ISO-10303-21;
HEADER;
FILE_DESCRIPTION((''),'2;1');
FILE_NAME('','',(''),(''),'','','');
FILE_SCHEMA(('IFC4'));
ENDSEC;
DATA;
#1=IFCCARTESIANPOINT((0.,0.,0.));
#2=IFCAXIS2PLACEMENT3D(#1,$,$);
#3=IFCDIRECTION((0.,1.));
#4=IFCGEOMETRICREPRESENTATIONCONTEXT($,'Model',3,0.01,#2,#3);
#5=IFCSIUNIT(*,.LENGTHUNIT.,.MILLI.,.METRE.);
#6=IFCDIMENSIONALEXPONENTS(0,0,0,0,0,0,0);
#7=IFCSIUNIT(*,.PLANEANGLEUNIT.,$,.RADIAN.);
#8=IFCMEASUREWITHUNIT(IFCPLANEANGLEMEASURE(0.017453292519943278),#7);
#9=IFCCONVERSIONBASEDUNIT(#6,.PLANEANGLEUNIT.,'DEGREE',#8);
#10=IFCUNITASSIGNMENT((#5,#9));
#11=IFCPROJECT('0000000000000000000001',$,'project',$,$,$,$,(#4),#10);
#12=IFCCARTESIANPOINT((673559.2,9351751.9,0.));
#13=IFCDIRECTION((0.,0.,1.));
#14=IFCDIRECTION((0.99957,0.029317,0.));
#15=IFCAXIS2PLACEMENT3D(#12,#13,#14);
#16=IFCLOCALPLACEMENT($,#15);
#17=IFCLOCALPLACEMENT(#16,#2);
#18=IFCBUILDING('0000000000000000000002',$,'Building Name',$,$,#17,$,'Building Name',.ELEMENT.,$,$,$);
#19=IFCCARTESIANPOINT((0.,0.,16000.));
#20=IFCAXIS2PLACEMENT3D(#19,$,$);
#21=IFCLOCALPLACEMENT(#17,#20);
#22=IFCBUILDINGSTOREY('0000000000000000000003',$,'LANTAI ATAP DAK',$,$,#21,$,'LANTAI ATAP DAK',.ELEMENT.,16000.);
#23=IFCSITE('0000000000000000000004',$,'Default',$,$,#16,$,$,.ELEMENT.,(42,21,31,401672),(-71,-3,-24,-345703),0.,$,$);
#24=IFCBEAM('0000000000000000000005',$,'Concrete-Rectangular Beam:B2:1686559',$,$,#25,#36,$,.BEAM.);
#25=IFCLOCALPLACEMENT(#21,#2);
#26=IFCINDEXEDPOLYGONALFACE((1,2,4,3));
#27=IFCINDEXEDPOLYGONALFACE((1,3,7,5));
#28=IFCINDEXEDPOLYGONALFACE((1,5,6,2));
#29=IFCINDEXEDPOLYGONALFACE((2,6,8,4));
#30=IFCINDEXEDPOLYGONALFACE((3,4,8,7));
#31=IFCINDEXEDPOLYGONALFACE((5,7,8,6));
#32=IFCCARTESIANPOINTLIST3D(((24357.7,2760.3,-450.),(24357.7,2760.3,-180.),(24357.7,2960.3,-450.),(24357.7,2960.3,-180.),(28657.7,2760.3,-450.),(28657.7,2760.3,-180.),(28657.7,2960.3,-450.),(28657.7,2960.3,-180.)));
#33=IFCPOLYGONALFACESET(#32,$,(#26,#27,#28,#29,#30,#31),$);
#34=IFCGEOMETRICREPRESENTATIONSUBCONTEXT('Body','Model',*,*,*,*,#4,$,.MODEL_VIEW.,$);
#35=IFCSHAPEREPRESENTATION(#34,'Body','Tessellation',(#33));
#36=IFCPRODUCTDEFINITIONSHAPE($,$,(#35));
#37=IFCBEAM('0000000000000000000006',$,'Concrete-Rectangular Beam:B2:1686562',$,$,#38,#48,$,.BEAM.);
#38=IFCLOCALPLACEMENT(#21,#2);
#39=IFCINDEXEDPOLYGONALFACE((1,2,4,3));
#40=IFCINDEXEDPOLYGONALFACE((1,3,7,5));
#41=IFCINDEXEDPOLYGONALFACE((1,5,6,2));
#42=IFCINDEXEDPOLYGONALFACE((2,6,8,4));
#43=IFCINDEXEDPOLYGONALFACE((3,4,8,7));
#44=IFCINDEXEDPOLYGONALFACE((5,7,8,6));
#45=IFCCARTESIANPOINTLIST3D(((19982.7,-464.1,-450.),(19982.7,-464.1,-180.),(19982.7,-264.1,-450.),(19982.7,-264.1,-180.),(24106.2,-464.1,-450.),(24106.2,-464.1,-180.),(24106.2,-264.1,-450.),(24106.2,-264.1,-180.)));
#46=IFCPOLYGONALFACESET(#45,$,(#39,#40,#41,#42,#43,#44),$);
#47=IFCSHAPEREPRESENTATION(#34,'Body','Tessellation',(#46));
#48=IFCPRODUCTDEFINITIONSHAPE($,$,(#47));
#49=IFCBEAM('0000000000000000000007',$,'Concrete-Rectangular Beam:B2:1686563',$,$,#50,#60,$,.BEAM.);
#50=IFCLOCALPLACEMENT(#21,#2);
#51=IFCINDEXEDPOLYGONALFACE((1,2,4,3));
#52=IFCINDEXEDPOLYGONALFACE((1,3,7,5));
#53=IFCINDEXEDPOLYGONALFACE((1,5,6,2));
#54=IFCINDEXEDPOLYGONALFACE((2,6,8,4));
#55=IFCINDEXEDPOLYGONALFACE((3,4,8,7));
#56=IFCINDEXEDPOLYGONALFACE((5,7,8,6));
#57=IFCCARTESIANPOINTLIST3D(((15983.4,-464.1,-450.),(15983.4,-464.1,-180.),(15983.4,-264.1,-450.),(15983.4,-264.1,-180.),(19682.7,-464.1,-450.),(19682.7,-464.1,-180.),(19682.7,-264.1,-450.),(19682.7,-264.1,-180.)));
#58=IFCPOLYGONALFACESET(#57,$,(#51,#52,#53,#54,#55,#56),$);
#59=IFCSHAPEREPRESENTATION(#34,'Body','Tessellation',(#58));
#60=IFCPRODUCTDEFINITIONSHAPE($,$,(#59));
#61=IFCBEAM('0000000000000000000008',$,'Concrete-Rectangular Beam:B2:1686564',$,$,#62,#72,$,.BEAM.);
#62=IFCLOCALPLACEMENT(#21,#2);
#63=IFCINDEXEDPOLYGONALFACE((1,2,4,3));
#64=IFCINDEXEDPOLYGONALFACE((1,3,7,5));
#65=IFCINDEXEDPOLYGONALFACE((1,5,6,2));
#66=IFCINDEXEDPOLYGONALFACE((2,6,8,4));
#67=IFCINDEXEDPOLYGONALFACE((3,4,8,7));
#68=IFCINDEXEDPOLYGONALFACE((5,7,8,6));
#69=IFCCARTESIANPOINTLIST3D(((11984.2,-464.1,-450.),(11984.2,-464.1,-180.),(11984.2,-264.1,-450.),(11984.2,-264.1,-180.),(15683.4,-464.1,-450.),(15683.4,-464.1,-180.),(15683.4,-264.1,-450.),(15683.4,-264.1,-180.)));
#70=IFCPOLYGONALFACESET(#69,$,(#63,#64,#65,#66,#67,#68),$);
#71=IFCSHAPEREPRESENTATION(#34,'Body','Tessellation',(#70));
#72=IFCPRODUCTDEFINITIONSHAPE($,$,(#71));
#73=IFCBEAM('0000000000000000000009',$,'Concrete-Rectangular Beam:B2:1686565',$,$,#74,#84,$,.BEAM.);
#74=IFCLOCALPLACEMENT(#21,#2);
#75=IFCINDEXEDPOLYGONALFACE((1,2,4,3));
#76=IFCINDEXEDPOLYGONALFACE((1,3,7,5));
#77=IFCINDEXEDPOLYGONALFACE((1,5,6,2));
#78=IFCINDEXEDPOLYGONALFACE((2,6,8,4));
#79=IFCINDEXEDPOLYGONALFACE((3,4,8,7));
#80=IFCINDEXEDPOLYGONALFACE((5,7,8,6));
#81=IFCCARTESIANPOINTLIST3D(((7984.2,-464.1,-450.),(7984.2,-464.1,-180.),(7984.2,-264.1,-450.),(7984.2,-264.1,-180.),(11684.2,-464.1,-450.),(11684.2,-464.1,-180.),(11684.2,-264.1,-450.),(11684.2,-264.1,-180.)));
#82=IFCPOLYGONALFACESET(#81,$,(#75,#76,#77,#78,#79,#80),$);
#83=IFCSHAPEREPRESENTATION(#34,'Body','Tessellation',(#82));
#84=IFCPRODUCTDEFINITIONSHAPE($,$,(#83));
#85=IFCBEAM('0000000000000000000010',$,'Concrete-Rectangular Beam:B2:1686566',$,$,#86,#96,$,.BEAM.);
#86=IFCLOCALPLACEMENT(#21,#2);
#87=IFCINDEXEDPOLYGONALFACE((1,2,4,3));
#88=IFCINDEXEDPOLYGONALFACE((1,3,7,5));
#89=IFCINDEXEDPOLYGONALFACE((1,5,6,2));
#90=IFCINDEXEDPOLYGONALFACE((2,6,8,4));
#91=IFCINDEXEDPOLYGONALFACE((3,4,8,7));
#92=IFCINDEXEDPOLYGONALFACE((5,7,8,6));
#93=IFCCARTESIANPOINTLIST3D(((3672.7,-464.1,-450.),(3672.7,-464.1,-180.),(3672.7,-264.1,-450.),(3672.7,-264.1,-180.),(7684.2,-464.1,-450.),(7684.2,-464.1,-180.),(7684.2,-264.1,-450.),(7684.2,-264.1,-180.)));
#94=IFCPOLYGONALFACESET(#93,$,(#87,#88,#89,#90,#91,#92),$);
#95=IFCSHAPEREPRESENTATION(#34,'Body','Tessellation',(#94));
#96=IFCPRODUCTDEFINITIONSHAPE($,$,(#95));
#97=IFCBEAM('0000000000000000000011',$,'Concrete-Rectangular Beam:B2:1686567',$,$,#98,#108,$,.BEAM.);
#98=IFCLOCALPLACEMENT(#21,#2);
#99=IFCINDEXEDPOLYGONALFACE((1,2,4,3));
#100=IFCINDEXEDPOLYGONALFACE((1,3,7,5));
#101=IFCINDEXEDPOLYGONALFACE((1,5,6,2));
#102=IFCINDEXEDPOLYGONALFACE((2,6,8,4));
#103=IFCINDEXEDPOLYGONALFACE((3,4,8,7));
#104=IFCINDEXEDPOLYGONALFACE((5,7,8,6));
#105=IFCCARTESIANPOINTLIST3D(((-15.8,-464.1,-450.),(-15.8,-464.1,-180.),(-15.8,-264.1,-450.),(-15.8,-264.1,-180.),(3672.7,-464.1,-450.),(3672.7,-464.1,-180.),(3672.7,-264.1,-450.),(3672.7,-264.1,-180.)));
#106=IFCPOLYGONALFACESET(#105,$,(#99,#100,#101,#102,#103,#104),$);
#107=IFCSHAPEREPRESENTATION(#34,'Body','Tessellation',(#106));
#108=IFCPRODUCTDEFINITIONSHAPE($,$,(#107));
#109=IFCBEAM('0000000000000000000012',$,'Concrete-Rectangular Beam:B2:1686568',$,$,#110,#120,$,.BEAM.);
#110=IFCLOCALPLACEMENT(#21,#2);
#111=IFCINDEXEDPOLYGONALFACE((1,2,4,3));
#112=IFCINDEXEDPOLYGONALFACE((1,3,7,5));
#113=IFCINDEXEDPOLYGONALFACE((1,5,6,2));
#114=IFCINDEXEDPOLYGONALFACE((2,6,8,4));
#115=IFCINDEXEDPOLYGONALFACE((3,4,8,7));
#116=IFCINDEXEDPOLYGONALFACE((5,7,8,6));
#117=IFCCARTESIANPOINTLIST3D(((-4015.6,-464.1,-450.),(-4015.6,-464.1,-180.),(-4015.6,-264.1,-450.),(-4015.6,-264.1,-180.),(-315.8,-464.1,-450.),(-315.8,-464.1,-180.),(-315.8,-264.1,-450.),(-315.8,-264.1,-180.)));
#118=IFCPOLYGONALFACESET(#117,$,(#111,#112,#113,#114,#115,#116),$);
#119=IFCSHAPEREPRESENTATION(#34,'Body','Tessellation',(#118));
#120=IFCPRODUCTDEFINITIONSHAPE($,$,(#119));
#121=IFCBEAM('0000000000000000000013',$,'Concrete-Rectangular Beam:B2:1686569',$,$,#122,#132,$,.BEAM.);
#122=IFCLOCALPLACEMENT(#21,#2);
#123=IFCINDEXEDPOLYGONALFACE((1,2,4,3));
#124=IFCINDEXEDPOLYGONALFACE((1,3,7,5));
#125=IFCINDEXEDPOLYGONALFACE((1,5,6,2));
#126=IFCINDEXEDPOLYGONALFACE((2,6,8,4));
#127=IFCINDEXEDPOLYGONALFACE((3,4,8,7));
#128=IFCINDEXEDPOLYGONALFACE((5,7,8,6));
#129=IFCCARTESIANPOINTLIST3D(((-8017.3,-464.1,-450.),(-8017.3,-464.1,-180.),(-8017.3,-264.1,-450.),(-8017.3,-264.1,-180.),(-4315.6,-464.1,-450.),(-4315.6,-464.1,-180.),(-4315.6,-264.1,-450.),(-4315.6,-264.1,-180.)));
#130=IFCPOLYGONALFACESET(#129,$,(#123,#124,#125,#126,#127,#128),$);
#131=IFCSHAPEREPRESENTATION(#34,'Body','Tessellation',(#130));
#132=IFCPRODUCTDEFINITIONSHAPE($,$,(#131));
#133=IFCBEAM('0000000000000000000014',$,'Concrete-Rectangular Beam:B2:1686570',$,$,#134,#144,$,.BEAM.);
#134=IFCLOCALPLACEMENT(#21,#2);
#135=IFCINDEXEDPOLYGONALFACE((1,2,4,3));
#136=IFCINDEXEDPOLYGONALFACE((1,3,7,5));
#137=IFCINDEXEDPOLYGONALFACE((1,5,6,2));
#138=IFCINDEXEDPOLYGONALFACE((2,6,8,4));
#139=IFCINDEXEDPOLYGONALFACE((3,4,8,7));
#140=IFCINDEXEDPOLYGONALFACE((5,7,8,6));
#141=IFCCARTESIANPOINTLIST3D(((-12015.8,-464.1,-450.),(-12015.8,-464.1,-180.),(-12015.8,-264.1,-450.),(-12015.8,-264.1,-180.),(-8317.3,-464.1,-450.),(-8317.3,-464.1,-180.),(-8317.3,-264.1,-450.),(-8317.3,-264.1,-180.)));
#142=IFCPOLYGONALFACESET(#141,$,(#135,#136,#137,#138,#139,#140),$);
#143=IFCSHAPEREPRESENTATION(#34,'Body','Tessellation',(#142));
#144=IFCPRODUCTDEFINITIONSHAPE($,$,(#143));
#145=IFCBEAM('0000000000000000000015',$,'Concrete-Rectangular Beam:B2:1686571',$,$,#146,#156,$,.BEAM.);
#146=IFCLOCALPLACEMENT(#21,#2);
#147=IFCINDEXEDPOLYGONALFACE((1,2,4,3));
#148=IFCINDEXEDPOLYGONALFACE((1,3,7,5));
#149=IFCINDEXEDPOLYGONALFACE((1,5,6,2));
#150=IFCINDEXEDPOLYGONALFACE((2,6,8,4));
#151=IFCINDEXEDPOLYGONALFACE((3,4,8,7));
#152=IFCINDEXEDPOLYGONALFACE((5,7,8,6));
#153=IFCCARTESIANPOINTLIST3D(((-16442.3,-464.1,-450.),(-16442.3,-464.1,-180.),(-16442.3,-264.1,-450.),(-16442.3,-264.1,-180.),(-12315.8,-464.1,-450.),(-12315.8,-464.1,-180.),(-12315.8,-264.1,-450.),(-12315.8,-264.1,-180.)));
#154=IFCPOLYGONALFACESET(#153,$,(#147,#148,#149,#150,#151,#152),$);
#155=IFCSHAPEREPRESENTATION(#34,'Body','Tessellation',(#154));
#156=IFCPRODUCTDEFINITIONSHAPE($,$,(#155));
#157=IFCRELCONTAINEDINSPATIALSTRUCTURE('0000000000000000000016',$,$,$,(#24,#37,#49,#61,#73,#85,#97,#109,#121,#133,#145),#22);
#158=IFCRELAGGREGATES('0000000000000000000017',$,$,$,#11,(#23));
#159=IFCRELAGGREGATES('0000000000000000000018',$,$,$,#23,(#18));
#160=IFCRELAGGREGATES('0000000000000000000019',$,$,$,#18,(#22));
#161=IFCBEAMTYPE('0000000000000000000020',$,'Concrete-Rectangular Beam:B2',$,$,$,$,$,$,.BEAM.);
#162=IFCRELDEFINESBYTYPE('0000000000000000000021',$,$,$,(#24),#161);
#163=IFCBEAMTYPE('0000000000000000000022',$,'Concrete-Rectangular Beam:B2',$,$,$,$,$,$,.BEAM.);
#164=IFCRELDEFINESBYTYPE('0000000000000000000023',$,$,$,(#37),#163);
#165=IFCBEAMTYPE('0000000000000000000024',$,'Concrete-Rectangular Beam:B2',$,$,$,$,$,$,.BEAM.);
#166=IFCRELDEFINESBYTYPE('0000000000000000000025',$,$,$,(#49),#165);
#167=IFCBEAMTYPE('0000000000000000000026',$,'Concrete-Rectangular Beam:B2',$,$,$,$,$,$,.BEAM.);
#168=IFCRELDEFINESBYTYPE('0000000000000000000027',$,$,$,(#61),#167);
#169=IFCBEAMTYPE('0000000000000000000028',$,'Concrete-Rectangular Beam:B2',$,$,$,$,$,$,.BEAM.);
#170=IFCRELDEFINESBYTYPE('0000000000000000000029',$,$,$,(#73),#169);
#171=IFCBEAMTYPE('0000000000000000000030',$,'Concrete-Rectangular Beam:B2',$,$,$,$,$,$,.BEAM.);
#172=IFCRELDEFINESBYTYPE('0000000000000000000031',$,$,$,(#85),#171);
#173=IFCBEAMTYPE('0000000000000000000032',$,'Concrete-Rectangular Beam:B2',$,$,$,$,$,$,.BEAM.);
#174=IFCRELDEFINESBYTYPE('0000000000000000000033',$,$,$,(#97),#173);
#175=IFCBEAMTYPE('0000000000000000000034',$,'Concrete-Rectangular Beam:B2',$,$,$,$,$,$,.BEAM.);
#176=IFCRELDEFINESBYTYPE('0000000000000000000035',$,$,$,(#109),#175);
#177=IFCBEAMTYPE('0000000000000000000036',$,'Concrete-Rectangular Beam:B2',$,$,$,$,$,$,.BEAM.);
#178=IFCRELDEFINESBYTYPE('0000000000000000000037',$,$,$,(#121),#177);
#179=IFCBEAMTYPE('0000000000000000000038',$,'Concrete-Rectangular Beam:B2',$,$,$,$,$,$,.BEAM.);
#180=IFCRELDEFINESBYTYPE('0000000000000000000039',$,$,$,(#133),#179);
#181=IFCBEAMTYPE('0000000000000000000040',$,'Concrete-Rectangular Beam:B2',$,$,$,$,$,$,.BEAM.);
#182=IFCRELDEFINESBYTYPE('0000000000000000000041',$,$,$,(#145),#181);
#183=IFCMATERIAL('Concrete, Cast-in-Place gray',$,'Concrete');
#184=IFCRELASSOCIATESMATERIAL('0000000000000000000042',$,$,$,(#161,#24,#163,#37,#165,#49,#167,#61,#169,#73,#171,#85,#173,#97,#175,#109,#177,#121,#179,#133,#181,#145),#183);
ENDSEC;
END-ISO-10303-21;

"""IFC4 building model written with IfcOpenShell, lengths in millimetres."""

from ifc_helpers import new_model, entity, si_unit, converted_unit, direction, frame, origin, place, context, subcontext, project, spatial, indexed_curve, outline, extrude, source, transform, mapped, material, type_object, type_shapes, element, save


model = new_model("IFC4")

# Units and contexts
model_context = context("Model", 3, precision=0.01, world=origin(), true_north=direction((0.0, 1.0)))
body_context = subcontext(model_context, "Body", "Model", "MODEL_VIEW")
ifc_project = project(units=[si_unit("LENGTHUNIT", "METRE", prefix="MILLI"), converted_unit("PLANEANGLEUNIT", "DEGREE", entity("IfcPlaneAngleMeasure", 0.017453292519943278), si_unit("PLANEANGLEUNIT", "RADIAN"), dimensions=[0, 0, 0, 0, 0, 0, 0])], contexts=[model_context])

# Site, building, storey
site_placement = place(None, frame((673559.2, 9351751.9, 0.0), z_axis=(0.0, 0.0, 1.0), x_axis=(0.99957, 0.029317, 0.0)))
site = spatial("IfcSite", under=ifc_project, at=site_placement, Name="Default", CompositionType="ELEMENT", RefLatitude=(42, 21, 31, 401672), RefLongitude=(-71, -3, -24, -345703), RefElevation=0.0)
building_placement = place(site_placement, origin())
building = spatial("IfcBuilding", under=site, at=building_placement, Name="Building Name", LongName="Building Name", CompositionType="ELEMENT")
storey_placement = place(building_placement, frame((0.0, 0.0, 16000.0)))
storey = spatial("IfcBuildingStorey", under=building, at=storey_placement, Name="LANTAI ATAP DAK", LongName="LANTAI ATAP DAK", CompositionType="ELEMENT", Elevation=16000.0)

# Beams
ifc_material = material(Name="Concrete, Cast-in-Place gray", Category="Concrete")
beam_type_1 = type_object("IfcBeamType", Name="Concrete-Rectangular Beam:B2", PredefinedType="BEAM", material=ifc_material)
shared_shape_1 = source(origin(), body_context, "Body", "SweptSolid", [
    extrude(outline(indexed_curve([(-135.0, -100.0), (135.0, -100.0), (135.0, 100.0), (-135.0, 100.0), (-135.0, -100.0)], self_intersect=False)), frame((24357.7, 2860.3, 15685.0), z_axis=(1.0, 0.0, 0.0), x_axis=(0.0, 0.0, -1.0)), (0.0, 0.0, 1.0), 4300.0),
])
type_shapes(beam_type_1, [shared_shape_1])
beam_1_placement = place(storey_placement, frame((0.0, 0.0, -16000.0)))
element("IfcBeam", 1, at=beam_1_placement, inside=storey, type_object=beam_type_1, material=ifc_material, Name="Concrete-Rectangular Beam:B2:1686559", PredefinedType="BEAM", context=body_context, shape_type="MappedRepresentation", body=[
    mapped(shared_shape_1, transform((0.0, 0.0, 0.0), scale=1.0)),
])
beam_type_2 = type_object("IfcBeamType", Name="Concrete-Rectangular Beam:B2", PredefinedType="BEAM", material=ifc_material)
shared_shape_2 = source(origin(), body_context, "Body", "SweptSolid", [
    extrude(outline(indexed_curve([(-135.0, -100.0), (135.0, -100.0), (135.0, 100.0), (-135.0, 100.0), (-135.0, -100.0)], self_intersect=False)), frame((24106.2, -364.1, 15685.0), z_axis=(-1.0, 0.0, 0.0), x_axis=(0.0, 0.0, -1.0)), (0.0, 0.0, 1.0), 4123.5),
])
type_shapes(beam_type_2, [shared_shape_2])
beam_2_placement = place(storey_placement, frame((0.0, 0.0, -16000.0)))
element("IfcBeam", 2, at=beam_2_placement, inside=storey, type_object=beam_type_2, material=ifc_material, Name="Concrete-Rectangular Beam:B2:1686562", PredefinedType="BEAM", context=body_context, shape_type="MappedRepresentation", body=[
    mapped(shared_shape_2, transform((0.0, 0.0, 0.0), scale=1.0)),
])
beam_type_3 = type_object("IfcBeamType", Name="Concrete-Rectangular Beam:B2", PredefinedType="BEAM", material=ifc_material)
shared_shape_3 = source(origin(), body_context, "Body", "SweptSolid", [
    extrude(outline(indexed_curve([(-135.0, -100.0), (135.0, -100.0), (135.0, 100.0), (-135.0, 100.0), (-135.0, -100.0)], self_intersect=False)), frame((19682.7, -364.1, 15685.0), z_axis=(-1.0, 0.0, 0.0), x_axis=(0.0, 0.0, -1.0)), (0.0, 0.0, 1.0), 3699.3),
])
type_shapes(beam_type_3, [shared_shape_3])
beam_3_placement = place(storey_placement, frame((0.0, 0.0, -16000.0)))
element("IfcBeam", 3, at=beam_3_placement, inside=storey, type_object=beam_type_3, material=ifc_material, Name="Concrete-Rectangular Beam:B2:1686563", PredefinedType="BEAM", context=body_context, shape_type="MappedRepresentation", body=[
    mapped(shared_shape_3, transform((0.0, 0.0, 0.0), scale=1.0)),
])
beam_type_4 = type_object("IfcBeamType", Name="Concrete-Rectangular Beam:B2", PredefinedType="BEAM", material=ifc_material)
shared_shape_4 = source(origin(), body_context, "Body", "SweptSolid", [
    extrude(outline(indexed_curve([(-135.0, -100.0), (135.0, -100.0), (135.0, 100.0), (-135.0, 100.0), (-135.0, -100.0)], self_intersect=False)), frame((11984.2, -364.1, 15685.0), z_axis=(1.0, 0.0, 0.0), x_axis=(0.0, 0.0, -1.0)), (0.0, 0.0, 1.0), 3699.3),
])
type_shapes(beam_type_4, [shared_shape_4])
beam_4_placement = place(storey_placement, frame((0.0, 0.0, -16000.0)))
element("IfcBeam", 4, at=beam_4_placement, inside=storey, type_object=beam_type_4, material=ifc_material, Name="Concrete-Rectangular Beam:B2:1686564", PredefinedType="BEAM", context=body_context, shape_type="MappedRepresentation", body=[
    mapped(shared_shape_4, transform((0.0, 0.0, 0.0), scale=1.0)),
])
beam_type_5 = type_object("IfcBeamType", Name="Concrete-Rectangular Beam:B2", PredefinedType="BEAM", material=ifc_material)
shared_shape_5 = source(origin(), body_context, "Body", "SweptSolid", [
    extrude(outline(indexed_curve([(-135.0, -100.0), (135.0, -100.0), (135.0, 100.0), (-135.0, 100.0), (-135.0, -100.0)], self_intersect=False)), frame((11684.2, -364.1, 15685.0), z_axis=(-1.0, 0.0, 0.0), x_axis=(0.0, 0.0, -1.0)), (0.0, 0.0, 1.0), 3700.0),
])
type_shapes(beam_type_5, [shared_shape_5])
beam_5_placement = place(storey_placement, frame((0.0, 0.0, -16000.0)))
element("IfcBeam", 5, at=beam_5_placement, inside=storey, type_object=beam_type_5, material=ifc_material, Name="Concrete-Rectangular Beam:B2:1686565", PredefinedType="BEAM", context=body_context, shape_type="MappedRepresentation", body=[
    mapped(shared_shape_5, transform((0.0, 0.0, 0.0), scale=1.0)),
])
beam_type_6 = type_object("IfcBeamType", Name="Concrete-Rectangular Beam:B2", PredefinedType="BEAM", material=ifc_material)
shared_shape_6 = source(origin(), body_context, "Body", "SweptSolid", [
    extrude(outline(indexed_curve([(-135.0, -100.0), (135.0, -100.0), (135.0, 100.0), (-135.0, 100.0), (-135.0, -100.0)], self_intersect=False)), frame((7684.2, -364.1, 15685.0), z_axis=(-1.0, 0.0, 0.0), x_axis=(0.0, 0.0, -1.0)), (0.0, 0.0, 1.0), 4011.4),
])
type_shapes(beam_type_6, [shared_shape_6])
beam_6_placement = place(storey_placement, frame((0.0, 0.0, -16000.0)))
element("IfcBeam", 6, at=beam_6_placement, inside=storey, type_object=beam_type_6, material=ifc_material, Name="Concrete-Rectangular Beam:B2:1686566", PredefinedType="BEAM", context=body_context, shape_type="MappedRepresentation", body=[
    mapped(shared_shape_6, transform((0.0, 0.0, 0.0), scale=1.0)),
])
beam_type_7 = type_object("IfcBeamType", Name="Concrete-Rectangular Beam:B2", PredefinedType="BEAM", material=ifc_material)
shared_shape_7 = source(origin(), body_context, "Body", "SweptSolid", [
    extrude(outline(indexed_curve([(-135.0, -100.0), (135.0, -100.0), (135.0, 100.0), (-135.0, 100.0), (-135.0, -100.0)], self_intersect=False)), frame((3672.7, -364.1, 15685.0), z_axis=(-1.0, 0.0, 0.0), x_axis=(0.0, 0.0, -1.0)), (0.0, 0.0, 1.0), 3688.6),
])
type_shapes(beam_type_7, [shared_shape_7])
beam_7_placement = place(storey_placement, frame((0.0, 0.0, -16000.0)))
element("IfcBeam", 7, at=beam_7_placement, inside=storey, type_object=beam_type_7, material=ifc_material, Name="Concrete-Rectangular Beam:B2:1686567", PredefinedType="BEAM", context=body_context, shape_type="MappedRepresentation", body=[
    mapped(shared_shape_7, transform((0.0, 0.0, 0.0), scale=1.0)),
])
beam_type_8 = type_object("IfcBeamType", Name="Concrete-Rectangular Beam:B2", PredefinedType="BEAM", material=ifc_material)
shared_shape_8 = source(origin(), body_context, "Body", "SweptSolid", [
    extrude(outline(indexed_curve([(-135.0, -100.0), (135.0, -100.0), (135.0, 100.0), (-135.0, 100.0), (-135.0, -100.0)], self_intersect=False)), frame((-315.8, -364.1, 15685.0), z_axis=(-1.0, 0.0, 0.0), x_axis=(0.0, 0.0, -1.0)), (0.0, 0.0, 1.0), 3699.7),
])
type_shapes(beam_type_8, [shared_shape_8])
beam_8_placement = place(storey_placement, frame((0.0, 0.0, -16000.0)))
element("IfcBeam", 8, at=beam_8_placement, inside=storey, type_object=beam_type_8, material=ifc_material, Name="Concrete-Rectangular Beam:B2:1686568", PredefinedType="BEAM", context=body_context, shape_type="MappedRepresentation", body=[
    mapped(shared_shape_8, transform((0.0, 0.0, 0.0), scale=1.0)),
])
beam_type_9 = type_object("IfcBeamType", Name="Concrete-Rectangular Beam:B2", PredefinedType="BEAM", material=ifc_material)
shared_shape_9 = source(origin(), body_context, "Body", "SweptSolid", [
    extrude(outline(indexed_curve([(-135.0, -100.0), (135.0, -100.0), (135.0, 100.0), (-135.0, 100.0), (-135.0, -100.0)], self_intersect=False)), frame((-4315.6, -364.1, 15685.0), z_axis=(-1.0, 0.0, 0.0), x_axis=(0.0, 0.0, -1.0)), (0.0, 0.0, 1.0), 3701.8),
])
type_shapes(beam_type_9, [shared_shape_9])
beam_9_placement = place(storey_placement, frame((0.0, 0.0, -16000.0)))
element("IfcBeam", 9, at=beam_9_placement, inside=storey, type_object=beam_type_9, material=ifc_material, Name="Concrete-Rectangular Beam:B2:1686569", PredefinedType="BEAM", context=body_context, shape_type="MappedRepresentation", body=[
    mapped(shared_shape_9, transform((0.0, 0.0, 0.0), scale=1.0)),
])
beam_type_10 = type_object("IfcBeamType", Name="Concrete-Rectangular Beam:B2", PredefinedType="BEAM", material=ifc_material)
shared_shape_10 = source(origin(), body_context, "Body", "SweptSolid", [
    extrude(outline(indexed_curve([(-135.0, -100.0), (135.0, -100.0), (135.0, 100.0), (-135.0, 100.0), (-135.0, -100.0)], self_intersect=False)), frame((-8317.3, -364.1, 15685.0), z_axis=(-1.0, 0.0, 0.0), x_axis=(0.0, 0.0, -1.0)), (0.0, 0.0, 1.0), 3698.5),
])
type_shapes(beam_type_10, [shared_shape_10])
beam_10_placement = place(storey_placement, frame((0.0, 0.0, -16000.0)))
element("IfcBeam", 10, at=beam_10_placement, inside=storey, type_object=beam_type_10, material=ifc_material, Name="Concrete-Rectangular Beam:B2:1686570", PredefinedType="BEAM", context=body_context, shape_type="MappedRepresentation", body=[
    mapped(shared_shape_10, transform((0.0, 0.0, 0.0), scale=1.0)),
])
beam_type_11 = type_object("IfcBeamType", Name="Concrete-Rectangular Beam:B2", PredefinedType="BEAM", material=ifc_material)
shared_shape_11 = source(origin(), body_context, "Body", "SweptSolid", [
    extrude(outline(indexed_curve([(-135.0, -100.0), (135.0, -100.0), (135.0, 100.0), (-135.0, 100.0), (-135.0, -100.0)], self_intersect=False)), frame((-12315.8, -364.1, 15685.0), z_axis=(-1.0, 0.0, 0.0), x_axis=(0.0, 0.0, -1.0)), (0.0, 0.0, 1.0), 4126.5),
])
type_shapes(beam_type_11, [shared_shape_11])
beam_11_placement = place(storey_placement, frame((0.0, 0.0, -16000.0)))
element("IfcBeam", 11, at=beam_11_placement, inside=storey, type_object=beam_type_11, material=ifc_material, Name="Concrete-Rectangular Beam:B2:1686571", PredefinedType="BEAM", context=body_context, shape_type="MappedRepresentation", body=[
    mapped(shared_shape_11, transform((0.0, 0.0, 0.0), scale=1.0)),
])

save(model, "model.ifc")
